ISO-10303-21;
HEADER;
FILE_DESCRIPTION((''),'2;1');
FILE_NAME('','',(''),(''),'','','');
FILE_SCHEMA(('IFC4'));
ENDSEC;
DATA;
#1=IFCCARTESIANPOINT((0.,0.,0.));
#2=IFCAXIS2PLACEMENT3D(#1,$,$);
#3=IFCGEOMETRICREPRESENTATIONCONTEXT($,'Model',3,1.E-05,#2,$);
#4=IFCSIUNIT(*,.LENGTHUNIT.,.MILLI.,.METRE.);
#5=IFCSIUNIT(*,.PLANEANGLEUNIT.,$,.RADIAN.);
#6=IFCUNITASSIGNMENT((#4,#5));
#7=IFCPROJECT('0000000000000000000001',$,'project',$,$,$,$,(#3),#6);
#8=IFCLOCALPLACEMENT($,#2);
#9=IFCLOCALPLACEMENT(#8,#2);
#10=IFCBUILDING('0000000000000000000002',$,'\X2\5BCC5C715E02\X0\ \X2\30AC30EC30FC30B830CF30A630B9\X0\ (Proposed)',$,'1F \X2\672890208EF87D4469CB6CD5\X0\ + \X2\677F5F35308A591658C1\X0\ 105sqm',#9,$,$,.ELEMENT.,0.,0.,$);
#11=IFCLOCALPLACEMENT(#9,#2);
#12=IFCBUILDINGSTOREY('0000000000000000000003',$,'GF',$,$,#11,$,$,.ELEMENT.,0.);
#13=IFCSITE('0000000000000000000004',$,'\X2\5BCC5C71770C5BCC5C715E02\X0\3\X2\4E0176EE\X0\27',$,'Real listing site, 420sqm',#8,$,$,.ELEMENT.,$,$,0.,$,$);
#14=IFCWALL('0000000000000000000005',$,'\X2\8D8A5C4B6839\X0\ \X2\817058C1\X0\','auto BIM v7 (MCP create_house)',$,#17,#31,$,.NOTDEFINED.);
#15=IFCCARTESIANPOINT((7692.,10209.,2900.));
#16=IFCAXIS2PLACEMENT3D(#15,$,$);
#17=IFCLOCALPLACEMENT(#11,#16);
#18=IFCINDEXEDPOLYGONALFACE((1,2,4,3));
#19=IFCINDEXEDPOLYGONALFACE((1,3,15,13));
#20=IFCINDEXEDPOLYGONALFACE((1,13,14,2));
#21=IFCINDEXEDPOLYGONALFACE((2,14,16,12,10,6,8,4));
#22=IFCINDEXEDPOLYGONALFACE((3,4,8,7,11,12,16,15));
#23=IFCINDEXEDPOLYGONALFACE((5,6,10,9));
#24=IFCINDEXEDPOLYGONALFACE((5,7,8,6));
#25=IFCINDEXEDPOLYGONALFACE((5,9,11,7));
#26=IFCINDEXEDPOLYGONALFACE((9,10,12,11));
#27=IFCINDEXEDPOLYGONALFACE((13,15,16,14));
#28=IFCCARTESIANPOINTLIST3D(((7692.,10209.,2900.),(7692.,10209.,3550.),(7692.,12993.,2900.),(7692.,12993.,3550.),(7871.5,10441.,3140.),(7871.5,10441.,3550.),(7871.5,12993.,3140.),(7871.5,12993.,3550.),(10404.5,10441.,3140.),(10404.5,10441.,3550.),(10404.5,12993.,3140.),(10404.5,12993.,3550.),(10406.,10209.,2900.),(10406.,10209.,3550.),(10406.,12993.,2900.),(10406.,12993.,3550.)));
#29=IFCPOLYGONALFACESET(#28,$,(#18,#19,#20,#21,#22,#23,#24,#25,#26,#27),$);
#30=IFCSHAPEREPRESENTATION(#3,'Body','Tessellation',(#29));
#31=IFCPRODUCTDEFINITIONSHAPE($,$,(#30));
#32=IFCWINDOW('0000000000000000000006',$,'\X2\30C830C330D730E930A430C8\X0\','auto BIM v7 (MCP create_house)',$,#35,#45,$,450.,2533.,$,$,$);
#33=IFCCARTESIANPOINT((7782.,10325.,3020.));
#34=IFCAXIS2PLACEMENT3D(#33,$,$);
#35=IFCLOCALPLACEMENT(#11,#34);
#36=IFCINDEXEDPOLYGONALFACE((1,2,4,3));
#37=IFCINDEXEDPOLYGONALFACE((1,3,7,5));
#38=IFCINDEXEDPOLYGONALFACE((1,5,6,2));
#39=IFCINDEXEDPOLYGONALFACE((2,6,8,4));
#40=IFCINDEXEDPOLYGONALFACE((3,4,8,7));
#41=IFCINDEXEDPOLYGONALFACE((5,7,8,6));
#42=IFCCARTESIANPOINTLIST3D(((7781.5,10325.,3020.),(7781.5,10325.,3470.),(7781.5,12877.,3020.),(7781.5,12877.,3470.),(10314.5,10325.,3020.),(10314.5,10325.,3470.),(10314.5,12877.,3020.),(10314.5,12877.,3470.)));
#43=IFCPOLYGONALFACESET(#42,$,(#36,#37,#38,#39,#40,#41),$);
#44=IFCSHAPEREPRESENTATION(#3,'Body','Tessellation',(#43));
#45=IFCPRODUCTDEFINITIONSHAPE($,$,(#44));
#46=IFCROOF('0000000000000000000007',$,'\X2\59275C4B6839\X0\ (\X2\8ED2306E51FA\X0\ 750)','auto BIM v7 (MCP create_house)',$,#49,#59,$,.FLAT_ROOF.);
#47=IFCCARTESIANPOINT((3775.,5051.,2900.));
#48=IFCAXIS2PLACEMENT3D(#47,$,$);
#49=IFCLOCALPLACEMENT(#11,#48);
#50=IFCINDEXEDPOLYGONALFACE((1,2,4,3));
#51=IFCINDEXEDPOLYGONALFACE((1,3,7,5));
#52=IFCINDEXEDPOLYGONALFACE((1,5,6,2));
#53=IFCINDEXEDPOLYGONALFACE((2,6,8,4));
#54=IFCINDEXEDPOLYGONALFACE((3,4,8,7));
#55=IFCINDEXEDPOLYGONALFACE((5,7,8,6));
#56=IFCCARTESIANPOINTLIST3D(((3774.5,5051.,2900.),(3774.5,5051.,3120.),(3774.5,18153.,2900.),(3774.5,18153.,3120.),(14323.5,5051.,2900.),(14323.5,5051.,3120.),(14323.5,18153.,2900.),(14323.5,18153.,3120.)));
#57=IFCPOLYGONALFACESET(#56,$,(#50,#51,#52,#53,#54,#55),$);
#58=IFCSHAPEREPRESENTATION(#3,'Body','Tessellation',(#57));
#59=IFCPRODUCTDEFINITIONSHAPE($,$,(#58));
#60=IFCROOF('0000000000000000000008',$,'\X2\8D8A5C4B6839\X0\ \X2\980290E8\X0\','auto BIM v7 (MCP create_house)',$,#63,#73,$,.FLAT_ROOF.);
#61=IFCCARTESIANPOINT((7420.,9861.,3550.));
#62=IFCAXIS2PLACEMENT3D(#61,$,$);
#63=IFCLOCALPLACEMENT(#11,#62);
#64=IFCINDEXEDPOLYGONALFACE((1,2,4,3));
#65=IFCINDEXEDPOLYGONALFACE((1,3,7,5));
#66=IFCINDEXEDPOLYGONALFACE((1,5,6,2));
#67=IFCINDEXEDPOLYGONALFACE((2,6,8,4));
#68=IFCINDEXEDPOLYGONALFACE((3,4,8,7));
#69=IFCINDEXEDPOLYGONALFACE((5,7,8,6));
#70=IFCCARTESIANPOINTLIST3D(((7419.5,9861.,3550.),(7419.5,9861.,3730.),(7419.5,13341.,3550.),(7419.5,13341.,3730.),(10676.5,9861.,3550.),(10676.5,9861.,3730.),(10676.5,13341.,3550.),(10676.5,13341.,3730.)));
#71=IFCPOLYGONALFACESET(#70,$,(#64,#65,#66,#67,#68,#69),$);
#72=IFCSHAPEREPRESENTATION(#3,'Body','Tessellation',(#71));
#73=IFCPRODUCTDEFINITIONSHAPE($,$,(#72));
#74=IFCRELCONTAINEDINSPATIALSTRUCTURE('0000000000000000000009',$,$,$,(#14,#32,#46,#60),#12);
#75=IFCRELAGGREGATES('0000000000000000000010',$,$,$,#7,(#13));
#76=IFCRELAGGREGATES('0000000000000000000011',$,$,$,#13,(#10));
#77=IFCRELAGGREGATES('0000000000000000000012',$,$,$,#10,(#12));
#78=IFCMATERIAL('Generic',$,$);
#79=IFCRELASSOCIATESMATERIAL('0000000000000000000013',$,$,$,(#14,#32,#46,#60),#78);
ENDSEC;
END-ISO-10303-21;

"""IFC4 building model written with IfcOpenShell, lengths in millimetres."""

from ifc_helpers import new_model, si_unit, frame, frame_2d, origin, place, context, project, spatial, rectangle, extrude, material, element, fill, save


model = new_model("IFC4")

# Units and contexts
model_context = context("Model", 3, precision=1e-05, world=origin())
ifc_project = project(units=[si_unit("LENGTHUNIT", "METRE", prefix="MILLI"), si_unit("PLANEANGLEUNIT", "RADIAN")], contexts=[model_context])

# Site, building, storey
site_placement = place(None, origin())
site = spatial("IfcSite", under=ifc_project, at=site_placement, Name="富山県富山市3丁目27", ObjectType="Real listing site, 420sqm", CompositionType="ELEMENT", RefElevation=0.0)
building_placement = place(site_placement, origin())
building = spatial("IfcBuilding", under=site, at=building_placement, Name="富山市 ガレージハウス (Proposed)", ObjectType="1F 木造軸組構法 + 板張り外壁 105sqm", CompositionType="ELEMENT", ElevationOfRefHeight=0.0, ElevationOfTerrain=0.0)
storey_placement = place(building_placement, origin())
storey = spatial("IfcBuildingStorey", under=building, at=storey_placement, Name="GF", CompositionType="ELEMENT", Elevation=0.0)

# Shared definitions
ifc_material = material(Name="Generic")

# Wall, opening, window
wall_1_placement = place(storey_placement, frame((7692.0, 10209.0, 2900.0)))
wall_1 = element("IfcWall", 1, at=wall_1_placement, inside=storey, material=ifc_material, Name="越屋根 腰壁", Description="auto BIM v7 (MCP create_house)", PredefinedType="NOTDEFINED", context=model_context, shape_type="SweptSolid", body=[
    extrude(rectangle(XDim=2714.0, YDim=2784.0, at=frame_2d((1357.0, 1392.0))), frame((7692.0, 10209.0, 2900.0)), (0.0, 0.0, 1.0), 650.0),
])
opening_1_placement = place(storey_placement, frame((7782.0, 10325.0, 3020.0)))
opening_1 = element("IfcOpeningElement", 2, at=opening_1_placement, cuts=wall_1, PredefinedType="NOTDEFINED", context=model_context, shape_type="SweptSolid", body=[
    extrude(rectangle(XDim=2533.0, YDim=2552.0, at=frame_2d((1266.0, 1276.0))), frame((7782.0, 10325.0, 3020.0)), (0.0, 0.0, 1.0), 450.0),
])
window_1_placement = place(storey_placement, frame((7782.0, 10325.0, 3020.0)))
window_1 = element("IfcWindow", 3, at=window_1_placement, inside=storey, material=ifc_material, Name="トップライト", Description="auto BIM v7 (MCP create_house)", OverallHeight=450.0, OverallWidth=2533.0, context=model_context, shape_type="SweptSolid", body=[
    extrude(rectangle(XDim=2533.0, YDim=2552.0, at=frame_2d((1266.0, 1276.0))), frame((7782.0, 10325.0, 3020.0)), (0.0, 0.0, 1.0), 450.0),
])
fill(opening_1, window_1)

# Roofs
roof_1_placement = place(storey_placement, frame((3775.0, 5051.0, 2900.0)))
element("IfcRoof", 4, at=roof_1_placement, inside=storey, material=ifc_material, Name="大屋根 (軒の出 750)", Description="auto BIM v7 (MCP create_house)", PredefinedType="FLAT_ROOF", context=model_context, shape_type="SweptSolid", body=[
    extrude(rectangle(XDim=10549.0, YDim=13102.0, at=frame_2d((5274.0, 6551.0))), frame((3775.0, 5051.0, 2900.0)), (0.0, 0.0, 1.0), 220.0),
])
roof_2_placement = place(storey_placement, frame((7420.0, 9861.0, 3550.0)))
element("IfcRoof", 5, at=roof_2_placement, inside=storey, material=ifc_material, Name="越屋根 頂部", Description="auto BIM v7 (MCP create_house)", PredefinedType="FLAT_ROOF", context=model_context, shape_type="SweptSolid", body=[
    extrude(rectangle(XDim=3257.0, YDim=3480.0, at=frame_2d((1628.0, 1740.0))), frame((7420.0, 9861.0, 3550.0)), (0.0, 0.0, 1.0), 180.0),
])

save(model, "model.ifc")
